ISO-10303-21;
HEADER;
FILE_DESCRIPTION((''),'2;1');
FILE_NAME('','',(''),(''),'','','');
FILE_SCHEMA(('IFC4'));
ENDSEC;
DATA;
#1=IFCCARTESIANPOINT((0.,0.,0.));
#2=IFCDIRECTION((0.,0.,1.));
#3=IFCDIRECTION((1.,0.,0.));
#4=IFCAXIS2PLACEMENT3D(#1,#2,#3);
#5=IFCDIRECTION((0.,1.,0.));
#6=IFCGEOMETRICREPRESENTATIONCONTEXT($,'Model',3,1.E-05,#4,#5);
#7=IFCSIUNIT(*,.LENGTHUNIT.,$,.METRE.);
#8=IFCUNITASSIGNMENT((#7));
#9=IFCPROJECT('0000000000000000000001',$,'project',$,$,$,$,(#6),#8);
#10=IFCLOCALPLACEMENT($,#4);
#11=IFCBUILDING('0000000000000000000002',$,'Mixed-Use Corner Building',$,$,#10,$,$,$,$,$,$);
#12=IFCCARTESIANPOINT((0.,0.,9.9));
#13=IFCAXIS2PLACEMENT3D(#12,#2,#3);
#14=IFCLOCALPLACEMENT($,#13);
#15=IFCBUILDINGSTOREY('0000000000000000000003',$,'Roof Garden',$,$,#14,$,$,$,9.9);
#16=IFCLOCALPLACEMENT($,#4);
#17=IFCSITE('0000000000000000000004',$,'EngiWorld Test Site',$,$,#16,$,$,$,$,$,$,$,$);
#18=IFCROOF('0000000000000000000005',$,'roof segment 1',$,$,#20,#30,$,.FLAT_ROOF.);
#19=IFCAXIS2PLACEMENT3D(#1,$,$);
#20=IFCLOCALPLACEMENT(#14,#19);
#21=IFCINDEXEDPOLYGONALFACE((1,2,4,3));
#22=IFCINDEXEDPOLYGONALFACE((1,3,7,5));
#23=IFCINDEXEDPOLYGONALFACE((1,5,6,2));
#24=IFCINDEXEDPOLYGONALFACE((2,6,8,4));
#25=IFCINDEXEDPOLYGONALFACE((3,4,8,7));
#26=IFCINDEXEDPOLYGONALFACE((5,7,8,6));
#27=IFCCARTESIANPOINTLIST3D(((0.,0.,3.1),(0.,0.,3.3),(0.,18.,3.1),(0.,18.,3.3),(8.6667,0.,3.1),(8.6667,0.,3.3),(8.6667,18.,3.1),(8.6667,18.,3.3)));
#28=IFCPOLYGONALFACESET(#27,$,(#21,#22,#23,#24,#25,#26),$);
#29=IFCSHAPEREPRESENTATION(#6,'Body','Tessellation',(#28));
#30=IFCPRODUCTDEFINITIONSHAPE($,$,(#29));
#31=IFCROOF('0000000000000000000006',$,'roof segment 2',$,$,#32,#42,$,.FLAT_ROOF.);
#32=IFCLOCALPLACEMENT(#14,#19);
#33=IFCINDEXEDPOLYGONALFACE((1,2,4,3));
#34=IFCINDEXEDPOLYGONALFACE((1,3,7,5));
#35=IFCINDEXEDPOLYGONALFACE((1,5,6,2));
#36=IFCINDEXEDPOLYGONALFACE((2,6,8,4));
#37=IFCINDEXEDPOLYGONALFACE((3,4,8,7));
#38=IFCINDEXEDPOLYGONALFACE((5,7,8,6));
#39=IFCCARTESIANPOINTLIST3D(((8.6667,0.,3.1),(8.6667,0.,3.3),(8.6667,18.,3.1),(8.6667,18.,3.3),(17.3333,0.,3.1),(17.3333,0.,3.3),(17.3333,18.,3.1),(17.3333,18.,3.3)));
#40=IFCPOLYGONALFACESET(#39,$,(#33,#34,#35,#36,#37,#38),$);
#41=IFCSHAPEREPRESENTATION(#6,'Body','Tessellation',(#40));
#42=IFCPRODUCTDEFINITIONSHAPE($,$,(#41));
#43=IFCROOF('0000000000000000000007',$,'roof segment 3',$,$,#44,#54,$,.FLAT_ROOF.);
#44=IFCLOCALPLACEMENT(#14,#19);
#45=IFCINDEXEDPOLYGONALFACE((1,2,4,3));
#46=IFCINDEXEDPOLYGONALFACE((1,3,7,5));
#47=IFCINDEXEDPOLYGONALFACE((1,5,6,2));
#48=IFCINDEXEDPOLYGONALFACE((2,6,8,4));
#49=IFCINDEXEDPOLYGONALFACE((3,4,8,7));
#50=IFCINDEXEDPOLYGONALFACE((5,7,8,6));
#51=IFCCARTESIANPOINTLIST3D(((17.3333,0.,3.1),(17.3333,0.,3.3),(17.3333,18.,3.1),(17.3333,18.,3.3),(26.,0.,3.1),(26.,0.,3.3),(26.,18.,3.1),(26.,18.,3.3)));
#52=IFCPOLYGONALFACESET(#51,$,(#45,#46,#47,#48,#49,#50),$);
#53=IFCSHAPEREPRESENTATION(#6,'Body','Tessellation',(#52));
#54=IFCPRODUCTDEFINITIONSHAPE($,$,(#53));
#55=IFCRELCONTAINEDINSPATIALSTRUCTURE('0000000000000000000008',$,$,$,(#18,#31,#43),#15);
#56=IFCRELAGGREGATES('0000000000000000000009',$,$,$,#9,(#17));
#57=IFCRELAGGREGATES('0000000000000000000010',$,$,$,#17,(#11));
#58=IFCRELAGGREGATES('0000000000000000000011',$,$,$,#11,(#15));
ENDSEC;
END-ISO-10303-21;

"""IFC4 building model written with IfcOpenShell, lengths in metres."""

from ifc_helpers import new_model, si_unit, direction, frame, origin_with_axes, origin_2d_with_axis, place, context, project, spatial, rectangle, extrude, element, save


model = new_model("IFC4")

# Units and contexts
model_context = context("Model", 3, precision=1e-05, world=origin_with_axes(), true_north=direction((0.0, 1.0, 0.0)))
ifc_project = project(units=[si_unit("LENGTHUNIT", "METRE")], contexts=[model_context])

# Site, building, storey
site_placement = place(None, origin_with_axes())
site = spatial("IfcSite", under=ifc_project, at=site_placement, Name="EngiWorld Test Site")
building_placement = place(None, origin_with_axes())
building = spatial("IfcBuilding", under=site, at=building_placement, Name="Mixed-Use Corner Building")
storey_placement = place(None, frame((0.0, 0.0, 9.9), z_axis=(0.0, 0.0, 1.0), x_axis=(1.0, 0.0, 0.0)))
storey = spatial("IfcBuildingStorey", under=building, at=storey_placement, Name="Roof Garden", Elevation=9.9)

# Roofs
for number, where, z_axis, x_axis, name in (
    (1, (4.3333, 9.0, 13.0), (0.0, 0.0, 1.0), (1.0, 0.0, 0.0), "roof segment 1"),
    (2, (13.0, 9.0, 13.0), (0.0, 0.0, 1.0), (1.0, 0.0, 0.0), "roof segment 2"),
    (3, (21.6667, 9.0, 13.0), (0.0, 0.0, 1.0), (1.0, 0.0, 0.0), "roof segment 3"),
):
    element("IfcRoof", number, at=place(None, frame(where, z_axis=z_axis, x_axis=x_axis)), inside=storey, Name=name, PredefinedType="FLAT_ROOF", context=model_context, shape_type="SweptSolid", body=[
        extrude(rectangle(XDim=8.6667, YDim=18.0, at=origin_2d_with_axis()), origin_with_axes(), (0.0, 0.0, 1.0), 0.2),
    ])

save(model, "model.ifc")
